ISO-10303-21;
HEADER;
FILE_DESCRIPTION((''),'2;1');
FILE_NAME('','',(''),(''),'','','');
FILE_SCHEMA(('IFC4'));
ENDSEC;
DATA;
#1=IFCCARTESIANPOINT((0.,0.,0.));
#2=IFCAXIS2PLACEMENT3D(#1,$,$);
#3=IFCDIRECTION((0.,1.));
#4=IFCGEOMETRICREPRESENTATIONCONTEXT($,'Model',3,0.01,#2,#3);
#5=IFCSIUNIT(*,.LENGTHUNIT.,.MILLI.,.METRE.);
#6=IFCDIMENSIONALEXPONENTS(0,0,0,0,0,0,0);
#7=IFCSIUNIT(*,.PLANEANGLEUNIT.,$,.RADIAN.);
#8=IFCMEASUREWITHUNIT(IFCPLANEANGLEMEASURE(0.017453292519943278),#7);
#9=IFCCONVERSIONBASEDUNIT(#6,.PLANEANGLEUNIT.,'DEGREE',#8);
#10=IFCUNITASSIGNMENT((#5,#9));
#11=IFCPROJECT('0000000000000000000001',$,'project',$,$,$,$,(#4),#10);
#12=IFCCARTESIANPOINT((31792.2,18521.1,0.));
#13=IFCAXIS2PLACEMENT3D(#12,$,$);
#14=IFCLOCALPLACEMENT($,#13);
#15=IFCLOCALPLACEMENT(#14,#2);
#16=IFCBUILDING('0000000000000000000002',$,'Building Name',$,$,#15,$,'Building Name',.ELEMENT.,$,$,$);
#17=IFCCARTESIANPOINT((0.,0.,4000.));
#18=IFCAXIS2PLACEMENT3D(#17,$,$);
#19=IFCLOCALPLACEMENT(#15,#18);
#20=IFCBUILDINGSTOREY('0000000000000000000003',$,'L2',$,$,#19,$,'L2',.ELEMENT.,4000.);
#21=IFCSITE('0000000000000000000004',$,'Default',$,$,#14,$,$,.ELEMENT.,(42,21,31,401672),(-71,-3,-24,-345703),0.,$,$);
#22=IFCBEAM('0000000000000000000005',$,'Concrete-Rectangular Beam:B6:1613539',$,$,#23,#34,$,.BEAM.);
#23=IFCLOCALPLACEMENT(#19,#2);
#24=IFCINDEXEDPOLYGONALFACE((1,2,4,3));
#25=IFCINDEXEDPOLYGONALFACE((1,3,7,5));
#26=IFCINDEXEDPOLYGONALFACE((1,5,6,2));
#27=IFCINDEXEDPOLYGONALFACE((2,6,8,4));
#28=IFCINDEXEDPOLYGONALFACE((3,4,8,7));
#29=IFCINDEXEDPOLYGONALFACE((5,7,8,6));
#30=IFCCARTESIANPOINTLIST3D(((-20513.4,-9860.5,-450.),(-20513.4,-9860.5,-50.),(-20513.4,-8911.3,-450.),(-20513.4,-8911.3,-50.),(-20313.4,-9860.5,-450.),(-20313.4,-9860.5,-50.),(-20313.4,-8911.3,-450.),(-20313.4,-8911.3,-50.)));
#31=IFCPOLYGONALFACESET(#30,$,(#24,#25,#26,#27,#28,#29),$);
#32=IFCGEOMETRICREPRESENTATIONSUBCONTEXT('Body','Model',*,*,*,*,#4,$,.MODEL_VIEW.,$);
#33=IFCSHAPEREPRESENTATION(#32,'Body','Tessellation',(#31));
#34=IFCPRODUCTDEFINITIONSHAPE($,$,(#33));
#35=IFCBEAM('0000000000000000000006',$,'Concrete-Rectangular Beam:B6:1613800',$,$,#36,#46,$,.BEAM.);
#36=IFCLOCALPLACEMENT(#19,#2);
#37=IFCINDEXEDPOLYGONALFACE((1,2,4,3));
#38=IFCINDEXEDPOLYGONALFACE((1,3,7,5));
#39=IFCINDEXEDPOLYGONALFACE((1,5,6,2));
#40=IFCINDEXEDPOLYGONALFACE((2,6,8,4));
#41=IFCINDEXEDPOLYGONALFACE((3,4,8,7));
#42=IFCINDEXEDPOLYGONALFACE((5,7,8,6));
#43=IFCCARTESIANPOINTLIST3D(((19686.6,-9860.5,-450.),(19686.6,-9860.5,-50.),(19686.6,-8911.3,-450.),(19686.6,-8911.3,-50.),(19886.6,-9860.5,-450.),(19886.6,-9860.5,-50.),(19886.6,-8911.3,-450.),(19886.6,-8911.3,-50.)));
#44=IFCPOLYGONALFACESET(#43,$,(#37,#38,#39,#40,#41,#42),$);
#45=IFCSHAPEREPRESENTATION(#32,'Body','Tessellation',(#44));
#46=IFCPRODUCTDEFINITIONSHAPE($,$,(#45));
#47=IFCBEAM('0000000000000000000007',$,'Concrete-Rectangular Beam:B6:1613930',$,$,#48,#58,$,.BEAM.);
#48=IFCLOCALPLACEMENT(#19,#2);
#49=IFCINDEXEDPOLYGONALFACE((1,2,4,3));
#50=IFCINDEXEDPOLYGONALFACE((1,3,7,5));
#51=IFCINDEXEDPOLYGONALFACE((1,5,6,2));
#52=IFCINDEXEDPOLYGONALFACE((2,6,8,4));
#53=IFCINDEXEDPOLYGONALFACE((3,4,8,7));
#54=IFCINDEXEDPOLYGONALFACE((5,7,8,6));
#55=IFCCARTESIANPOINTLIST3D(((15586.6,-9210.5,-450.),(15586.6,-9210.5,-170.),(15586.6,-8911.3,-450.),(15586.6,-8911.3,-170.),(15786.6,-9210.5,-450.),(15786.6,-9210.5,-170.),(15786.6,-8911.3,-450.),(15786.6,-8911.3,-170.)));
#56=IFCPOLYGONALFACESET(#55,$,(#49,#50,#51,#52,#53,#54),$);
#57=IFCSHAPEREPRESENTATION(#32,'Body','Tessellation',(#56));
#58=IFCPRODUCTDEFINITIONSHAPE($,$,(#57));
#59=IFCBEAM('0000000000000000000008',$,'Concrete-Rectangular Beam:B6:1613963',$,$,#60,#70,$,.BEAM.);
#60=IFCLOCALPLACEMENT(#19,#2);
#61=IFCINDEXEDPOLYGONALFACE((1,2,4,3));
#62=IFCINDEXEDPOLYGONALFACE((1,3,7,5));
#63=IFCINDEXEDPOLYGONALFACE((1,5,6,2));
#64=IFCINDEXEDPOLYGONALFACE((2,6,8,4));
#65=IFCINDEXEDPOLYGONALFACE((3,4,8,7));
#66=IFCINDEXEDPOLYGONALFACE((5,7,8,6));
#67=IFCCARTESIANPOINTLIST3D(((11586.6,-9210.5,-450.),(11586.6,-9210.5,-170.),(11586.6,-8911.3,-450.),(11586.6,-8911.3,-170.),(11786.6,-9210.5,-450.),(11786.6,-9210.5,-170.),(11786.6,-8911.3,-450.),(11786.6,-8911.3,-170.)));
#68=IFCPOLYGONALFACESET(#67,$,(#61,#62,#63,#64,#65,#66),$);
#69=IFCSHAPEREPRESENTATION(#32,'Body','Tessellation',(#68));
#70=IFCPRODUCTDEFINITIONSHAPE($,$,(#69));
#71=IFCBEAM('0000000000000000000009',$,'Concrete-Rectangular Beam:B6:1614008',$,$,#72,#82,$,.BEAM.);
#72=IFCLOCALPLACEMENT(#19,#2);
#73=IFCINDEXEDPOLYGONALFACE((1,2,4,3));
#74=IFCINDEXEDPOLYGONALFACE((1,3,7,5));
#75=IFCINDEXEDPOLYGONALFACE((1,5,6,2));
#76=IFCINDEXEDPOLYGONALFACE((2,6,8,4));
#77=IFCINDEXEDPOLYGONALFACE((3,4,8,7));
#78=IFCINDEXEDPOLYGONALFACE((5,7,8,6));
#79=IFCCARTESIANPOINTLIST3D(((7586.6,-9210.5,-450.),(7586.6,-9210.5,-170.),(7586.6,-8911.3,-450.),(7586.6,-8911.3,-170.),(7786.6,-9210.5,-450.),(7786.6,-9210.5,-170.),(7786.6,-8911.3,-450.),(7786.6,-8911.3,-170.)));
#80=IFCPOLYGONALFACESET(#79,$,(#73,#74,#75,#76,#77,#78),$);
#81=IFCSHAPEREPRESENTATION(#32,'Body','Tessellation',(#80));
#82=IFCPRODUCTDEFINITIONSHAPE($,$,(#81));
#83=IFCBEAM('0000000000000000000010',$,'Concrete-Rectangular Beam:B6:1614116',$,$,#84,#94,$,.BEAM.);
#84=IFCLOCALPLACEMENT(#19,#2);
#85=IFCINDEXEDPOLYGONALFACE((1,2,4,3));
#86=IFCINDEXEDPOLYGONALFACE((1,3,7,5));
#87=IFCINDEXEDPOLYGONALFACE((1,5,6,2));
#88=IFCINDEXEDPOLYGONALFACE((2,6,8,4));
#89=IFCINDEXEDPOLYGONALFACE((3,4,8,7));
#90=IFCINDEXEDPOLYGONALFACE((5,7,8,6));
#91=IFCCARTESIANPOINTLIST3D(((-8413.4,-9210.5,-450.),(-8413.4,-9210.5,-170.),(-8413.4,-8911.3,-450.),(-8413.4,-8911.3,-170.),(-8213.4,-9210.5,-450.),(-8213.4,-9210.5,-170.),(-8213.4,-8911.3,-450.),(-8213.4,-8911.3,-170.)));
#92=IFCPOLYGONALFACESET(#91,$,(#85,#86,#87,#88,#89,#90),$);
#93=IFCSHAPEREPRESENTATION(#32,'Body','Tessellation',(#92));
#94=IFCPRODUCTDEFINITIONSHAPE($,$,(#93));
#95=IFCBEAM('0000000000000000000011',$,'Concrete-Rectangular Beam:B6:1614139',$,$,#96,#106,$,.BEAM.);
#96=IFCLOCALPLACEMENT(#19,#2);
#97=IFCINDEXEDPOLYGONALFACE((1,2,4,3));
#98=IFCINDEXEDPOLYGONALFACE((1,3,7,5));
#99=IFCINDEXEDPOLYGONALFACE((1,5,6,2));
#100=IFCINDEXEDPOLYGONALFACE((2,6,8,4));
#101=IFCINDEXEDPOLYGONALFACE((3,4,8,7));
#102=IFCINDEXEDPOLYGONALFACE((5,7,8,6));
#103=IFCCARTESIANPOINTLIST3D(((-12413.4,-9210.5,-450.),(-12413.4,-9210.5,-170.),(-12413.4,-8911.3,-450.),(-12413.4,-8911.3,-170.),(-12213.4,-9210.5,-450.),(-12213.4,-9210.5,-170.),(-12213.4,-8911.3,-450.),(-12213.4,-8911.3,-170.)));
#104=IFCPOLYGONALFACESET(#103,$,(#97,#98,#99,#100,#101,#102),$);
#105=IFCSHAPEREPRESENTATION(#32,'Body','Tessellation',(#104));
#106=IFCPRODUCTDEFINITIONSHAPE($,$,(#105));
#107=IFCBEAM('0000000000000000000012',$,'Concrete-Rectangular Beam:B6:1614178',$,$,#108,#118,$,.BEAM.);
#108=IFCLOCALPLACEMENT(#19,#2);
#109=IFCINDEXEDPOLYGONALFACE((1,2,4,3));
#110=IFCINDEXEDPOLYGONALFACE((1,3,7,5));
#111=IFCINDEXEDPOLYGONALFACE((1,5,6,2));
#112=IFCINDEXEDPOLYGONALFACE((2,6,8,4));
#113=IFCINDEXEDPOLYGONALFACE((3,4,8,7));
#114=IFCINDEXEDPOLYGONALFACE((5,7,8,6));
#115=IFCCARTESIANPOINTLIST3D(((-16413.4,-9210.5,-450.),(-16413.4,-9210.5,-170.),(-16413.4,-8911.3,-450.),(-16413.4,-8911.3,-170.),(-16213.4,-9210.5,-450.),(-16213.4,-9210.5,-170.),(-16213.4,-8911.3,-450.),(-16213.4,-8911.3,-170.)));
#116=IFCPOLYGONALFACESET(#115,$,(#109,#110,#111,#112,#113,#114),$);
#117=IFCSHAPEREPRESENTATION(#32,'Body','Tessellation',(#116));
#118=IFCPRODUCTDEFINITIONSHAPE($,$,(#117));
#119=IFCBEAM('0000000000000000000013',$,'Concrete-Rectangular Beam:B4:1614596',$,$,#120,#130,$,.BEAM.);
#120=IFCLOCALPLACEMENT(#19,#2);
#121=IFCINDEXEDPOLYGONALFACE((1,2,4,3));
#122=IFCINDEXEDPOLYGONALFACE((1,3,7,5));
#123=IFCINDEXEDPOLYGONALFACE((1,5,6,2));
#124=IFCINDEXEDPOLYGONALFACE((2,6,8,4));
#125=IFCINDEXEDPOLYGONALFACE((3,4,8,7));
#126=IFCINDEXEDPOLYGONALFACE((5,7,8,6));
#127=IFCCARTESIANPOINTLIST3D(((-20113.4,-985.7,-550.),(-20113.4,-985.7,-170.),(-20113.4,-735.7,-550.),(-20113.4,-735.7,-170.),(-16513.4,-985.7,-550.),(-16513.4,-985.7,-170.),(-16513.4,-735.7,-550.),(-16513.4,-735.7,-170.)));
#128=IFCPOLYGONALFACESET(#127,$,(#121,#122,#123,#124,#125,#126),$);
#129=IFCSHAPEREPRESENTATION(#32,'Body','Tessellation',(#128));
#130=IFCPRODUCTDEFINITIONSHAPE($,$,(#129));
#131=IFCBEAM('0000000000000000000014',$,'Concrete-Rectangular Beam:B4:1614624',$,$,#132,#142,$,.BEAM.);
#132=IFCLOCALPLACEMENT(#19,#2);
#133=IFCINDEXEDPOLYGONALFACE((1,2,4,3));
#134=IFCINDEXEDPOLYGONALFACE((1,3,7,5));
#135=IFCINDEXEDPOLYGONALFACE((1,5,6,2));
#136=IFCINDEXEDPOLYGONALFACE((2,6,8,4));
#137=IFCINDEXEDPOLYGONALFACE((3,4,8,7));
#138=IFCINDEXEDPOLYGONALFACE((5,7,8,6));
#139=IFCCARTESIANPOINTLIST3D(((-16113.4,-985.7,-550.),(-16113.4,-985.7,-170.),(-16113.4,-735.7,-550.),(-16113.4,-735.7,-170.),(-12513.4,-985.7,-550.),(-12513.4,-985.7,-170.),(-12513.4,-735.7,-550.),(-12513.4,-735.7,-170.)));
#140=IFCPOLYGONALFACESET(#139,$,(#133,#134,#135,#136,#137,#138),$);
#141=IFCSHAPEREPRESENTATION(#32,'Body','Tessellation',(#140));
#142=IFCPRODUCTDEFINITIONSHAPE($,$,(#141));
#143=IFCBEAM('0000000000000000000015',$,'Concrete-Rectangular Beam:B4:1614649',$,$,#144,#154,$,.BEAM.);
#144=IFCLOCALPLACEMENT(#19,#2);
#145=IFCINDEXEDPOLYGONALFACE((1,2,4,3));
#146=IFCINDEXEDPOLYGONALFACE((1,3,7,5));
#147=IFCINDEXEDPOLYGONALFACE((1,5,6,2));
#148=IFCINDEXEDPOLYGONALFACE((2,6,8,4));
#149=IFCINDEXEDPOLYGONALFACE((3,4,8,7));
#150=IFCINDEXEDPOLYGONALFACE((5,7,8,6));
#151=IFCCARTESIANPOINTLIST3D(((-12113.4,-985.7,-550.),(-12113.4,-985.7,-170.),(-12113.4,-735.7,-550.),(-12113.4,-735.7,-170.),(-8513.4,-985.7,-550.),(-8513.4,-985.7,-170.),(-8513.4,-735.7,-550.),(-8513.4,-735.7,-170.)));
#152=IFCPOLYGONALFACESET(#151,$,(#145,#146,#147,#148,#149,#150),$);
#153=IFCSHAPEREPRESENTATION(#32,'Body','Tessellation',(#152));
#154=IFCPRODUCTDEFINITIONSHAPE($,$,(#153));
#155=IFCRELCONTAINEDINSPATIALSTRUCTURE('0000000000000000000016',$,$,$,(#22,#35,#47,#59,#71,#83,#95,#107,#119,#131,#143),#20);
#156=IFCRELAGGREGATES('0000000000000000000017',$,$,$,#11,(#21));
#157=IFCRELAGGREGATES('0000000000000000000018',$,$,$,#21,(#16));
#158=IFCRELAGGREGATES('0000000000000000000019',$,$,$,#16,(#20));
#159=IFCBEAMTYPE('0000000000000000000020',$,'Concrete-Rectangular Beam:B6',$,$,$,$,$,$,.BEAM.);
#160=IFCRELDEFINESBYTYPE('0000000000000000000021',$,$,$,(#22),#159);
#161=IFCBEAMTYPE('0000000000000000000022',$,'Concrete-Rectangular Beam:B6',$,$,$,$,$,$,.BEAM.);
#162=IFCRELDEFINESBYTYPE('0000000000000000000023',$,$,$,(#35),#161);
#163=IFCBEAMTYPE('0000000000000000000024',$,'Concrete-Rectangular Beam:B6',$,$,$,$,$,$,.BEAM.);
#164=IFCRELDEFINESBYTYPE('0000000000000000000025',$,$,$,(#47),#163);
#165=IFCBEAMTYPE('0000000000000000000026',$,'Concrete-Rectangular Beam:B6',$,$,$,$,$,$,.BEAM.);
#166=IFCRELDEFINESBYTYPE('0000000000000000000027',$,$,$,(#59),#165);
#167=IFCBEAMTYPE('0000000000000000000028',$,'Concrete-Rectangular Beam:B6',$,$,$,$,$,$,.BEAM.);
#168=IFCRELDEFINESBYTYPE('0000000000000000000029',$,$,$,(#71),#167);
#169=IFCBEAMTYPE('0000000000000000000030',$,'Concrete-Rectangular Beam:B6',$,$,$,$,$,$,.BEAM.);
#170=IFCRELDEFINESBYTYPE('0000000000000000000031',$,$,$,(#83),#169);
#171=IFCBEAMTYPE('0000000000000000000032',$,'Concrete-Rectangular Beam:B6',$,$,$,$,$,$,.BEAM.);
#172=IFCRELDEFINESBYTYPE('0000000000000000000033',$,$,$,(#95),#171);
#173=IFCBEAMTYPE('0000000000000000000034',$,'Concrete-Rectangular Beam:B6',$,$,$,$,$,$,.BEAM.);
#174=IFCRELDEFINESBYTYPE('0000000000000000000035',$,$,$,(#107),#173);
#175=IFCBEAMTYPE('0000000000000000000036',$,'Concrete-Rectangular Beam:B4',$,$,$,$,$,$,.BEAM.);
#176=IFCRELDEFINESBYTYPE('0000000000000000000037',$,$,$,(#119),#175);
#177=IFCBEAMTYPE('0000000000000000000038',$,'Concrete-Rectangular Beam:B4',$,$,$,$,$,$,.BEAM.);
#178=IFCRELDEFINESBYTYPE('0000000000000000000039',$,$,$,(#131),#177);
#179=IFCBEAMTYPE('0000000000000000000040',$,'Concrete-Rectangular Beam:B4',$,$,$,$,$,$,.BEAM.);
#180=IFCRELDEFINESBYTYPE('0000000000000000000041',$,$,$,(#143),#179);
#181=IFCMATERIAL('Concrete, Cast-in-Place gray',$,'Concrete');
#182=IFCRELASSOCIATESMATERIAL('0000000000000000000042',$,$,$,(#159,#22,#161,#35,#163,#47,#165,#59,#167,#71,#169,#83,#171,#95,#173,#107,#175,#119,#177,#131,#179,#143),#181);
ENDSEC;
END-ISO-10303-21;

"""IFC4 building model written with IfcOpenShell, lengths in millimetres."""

from ifc_helpers import new_model, entity, si_unit, converted_unit, direction, frame, origin, place, context, subcontext, project, spatial, indexed_curve, outline, extrude, source, transform, mapped, material, type_object, type_shapes, element, save


model = new_model("IFC4")

# Units and contexts
model_context = context("Model", 3, precision=0.01, world=origin(), true_north=direction((0.0, 1.0)))
body_context = subcontext(model_context, "Body", "Model", "MODEL_VIEW")
ifc_project = project(units=[si_unit("LENGTHUNIT", "METRE", prefix="MILLI"), converted_unit("PLANEANGLEUNIT", "DEGREE", entity("IfcPlaneAngleMeasure", 0.017453292519943278), si_unit("PLANEANGLEUNIT", "RADIAN"), dimensions=[0, 0, 0, 0, 0, 0, 0])], contexts=[model_context])

# Site, building, storey
site_placement = place(None, frame((31792.2, 18521.1, 0.0)))
site = spatial("IfcSite", under=ifc_project, at=site_placement, Name="Default", CompositionType="ELEMENT", RefLatitude=(42, 21, 31, 401672), RefLongitude=(-71, -3, -24, -345703), RefElevation=0.0)
building_placement = place(site_placement, origin())
building = spatial("IfcBuilding", under=site, at=building_placement, Name="Building Name", LongName="Building Name", CompositionType="ELEMENT")
storey_placement = place(building_placement, frame((0.0, 0.0, 4000.0)))
storey = spatial("IfcBuildingStorey", under=building, at=storey_placement, Name="L2", LongName="L2", CompositionType="ELEMENT", Elevation=4000.0)

# Beams
ifc_material = material(Name="Concrete, Cast-in-Place gray", Category="Concrete")
beam_type_1 = type_object("IfcBeamType", Name="Concrete-Rectangular Beam:B6", PredefinedType="BEAM", material=ifc_material)
shared_shape_1 = source(origin(), body_context, "Body", "SweptSolid", [
    extrude(outline(indexed_curve([(-100.0, -200.0), (100.0, -200.0), (100.0, 200.0), (-100.0, 200.0), (-100.0, -200.0)], self_intersect=False)), frame((-20413.4, -9860.5, 3750.0), z_axis=(0.0, 1.0, 0.0), x_axis=(-1.0, 0.0, 0.0)), (0.0, 0.0, 1.0), 949.2),
])
type_shapes(beam_type_1, [shared_shape_1])
beam_1_placement = place(storey_placement, frame((0.0, 0.0, -4000.0)))
element("IfcBeam", 1, at=beam_1_placement, inside=storey, type_object=beam_type_1, material=ifc_material, Name="Concrete-Rectangular Beam:B6:1613539", PredefinedType="BEAM", context=body_context, shape_type="MappedRepresentation", body=[
    mapped(shared_shape_1, transform((0.0, 0.0, 0.0), scale=1.0)),
])
beam_type_2 = type_object("IfcBeamType", Name="Concrete-Rectangular Beam:B6", PredefinedType="BEAM", material=ifc_material)
shared_shape_2 = source(origin(), body_context, "Body", "SweptSolid", [
    extrude(outline(indexed_curve([(-100.0, -200.0), (100.0, -200.0), (100.0, 200.0), (-100.0, 200.0), (-100.0, -200.0)], self_intersect=False)), frame((19786.6, -9860.5, 3750.0), z_axis=(0.0, 1.0, 0.0), x_axis=(-1.0, 0.0, 0.0)), (0.0, 0.0, 1.0), 949.2),
])
type_shapes(beam_type_2, [shared_shape_2])
beam_2_placement = place(storey_placement, frame((0.0, 0.0, -4000.0)))
element("IfcBeam", 2, at=beam_2_placement, inside=storey, type_object=beam_type_2, material=ifc_material, Name="Concrete-Rectangular Beam:B6:1613800", PredefinedType="BEAM", context=body_context, shape_type="MappedRepresentation", body=[
    mapped(shared_shape_2, transform((0.0, 0.0, 0.0), scale=1.0)),
])
beam_type_3 = type_object("IfcBeamType", Name="Concrete-Rectangular Beam:B6", PredefinedType="BEAM", material=ifc_material)
shared_shape_3 = source(origin(), body_context, "Body", "SweptSolid", [
    extrude(outline(indexed_curve([(-100.0, -140.0), (100.0, -140.0), (100.0, 140.0), (-100.0, 140.0), (-100.0, -140.0)], self_intersect=False)), frame((15686.6, -8911.3, 3690.0), z_axis=(0.0, -1.0, 0.0), x_axis=(-1.0, 0.0, 0.0)), (0.0, 0.0, 1.0), 299.2),
])
type_shapes(beam_type_3, [shared_shape_3])
beam_3_placement = place(storey_placement, frame((0.0, 0.0, -4000.0)))
element("IfcBeam", 3, at=beam_3_placement, inside=storey, type_object=beam_type_3, material=ifc_material, Name="Concrete-Rectangular Beam:B6:1613930", PredefinedType="BEAM", context=body_context, shape_type="MappedRepresentation", body=[
    mapped(shared_shape_3, transform((0.0, 0.0, 0.0), scale=1.0)),
])
beam_type_4 = type_object("IfcBeamType", Name="Concrete-Rectangular Beam:B6", PredefinedType="BEAM", material=ifc_material)
shared_shape_4 = source(origin(), body_context, "Body", "SweptSolid", [
    extrude(outline(indexed_curve([(-100.0, -140.0), (100.0, -140.0), (100.0, 140.0), (-100.0, 140.0), (-100.0, -140.0)], self_intersect=False)), frame((11686.6, -8911.3, 3690.0), z_axis=(0.0, -1.0, 0.0), x_axis=(-1.0, 0.0, 0.0)), (0.0, 0.0, 1.0), 299.2),
])
type_shapes(beam_type_4, [shared_shape_4])
beam_4_placement = place(storey_placement, frame((0.0, 0.0, -4000.0)))
element("IfcBeam", 4, at=beam_4_placement, inside=storey, type_object=beam_type_4, material=ifc_material, Name="Concrete-Rectangular Beam:B6:1613963", PredefinedType="BEAM", context=body_context, shape_type="MappedRepresentation", body=[
    mapped(shared_shape_4, transform((0.0, 0.0, 0.0), scale=1.0)),
])
beam_type_5 = type_object("IfcBeamType", Name="Concrete-Rectangular Beam:B6", PredefinedType="BEAM", material=ifc_material)
shared_shape_5 = source(origin(), body_context, "Body", "SweptSolid", [
    extrude(outline(indexed_curve([(-100.0, -140.0), (100.0, -140.0), (100.0, 140.0), (-100.0, 140.0), (-100.0, -140.0)], self_intersect=False)), frame((7686.6, -8911.3, 3690.0), z_axis=(0.0, -1.0, 0.0), x_axis=(-1.0, 0.0, 0.0)), (0.0, 0.0, 1.0), 299.2),
])
type_shapes(beam_type_5, [shared_shape_5])
beam_5_placement = place(storey_placement, frame((0.0, 0.0, -4000.0)))
element("IfcBeam", 5, at=beam_5_placement, inside=storey, type_object=beam_type_5, material=ifc_material, Name="Concrete-Rectangular Beam:B6:1614008", PredefinedType="BEAM", context=body_context, shape_type="MappedRepresentation", body=[
    mapped(shared_shape_5, transform((0.0, 0.0, 0.0), scale=1.0)),
])
beam_type_6 = type_object("IfcBeamType", Name="Concrete-Rectangular Beam:B6", PredefinedType="BEAM", material=ifc_material)
shared_shape_6 = source(origin(), body_context, "Body", "SweptSolid", [
    extrude(outline(indexed_curve([(-100.0, -140.0), (100.0, -140.0), (100.0, 140.0), (-100.0, 140.0), (-100.0, -140.0)], self_intersect=False)), frame((-8313.4, -8911.3, 3690.0), z_axis=(0.0, -1.0, 0.0), x_axis=(-1.0, 0.0, 0.0)), (0.0, 0.0, 1.0), 299.2),
])
type_shapes(beam_type_6, [shared_shape_6])
beam_6_placement = place(storey_placement, frame((0.0, 0.0, -4000.0)))
element("IfcBeam", 6, at=beam_6_placement, inside=storey, type_object=beam_type_6, material=ifc_material, Name="Concrete-Rectangular Beam:B6:1614116", PredefinedType="BEAM", context=body_context, shape_type="MappedRepresentation", body=[
    mapped(shared_shape_6, transform((0.0, 0.0, 0.0), scale=1.0)),
])
beam_type_7 = type_object("IfcBeamType", Name="Concrete-Rectangular Beam:B6", PredefinedType="BEAM", material=ifc_material)
shared_shape_7 = source(origin(), body_context, "Body", "SweptSolid", [
    extrude(outline(indexed_curve([(-100.0, -140.0), (100.0, -140.0), (100.0, 140.0), (-100.0, 140.0), (-100.0, -140.0)], self_intersect=False)), frame((-12313.4, -8911.3, 3690.0), z_axis=(0.0, -1.0, 0.0), x_axis=(-1.0, 0.0, 0.0)), (0.0, 0.0, 1.0), 299.2),
])
type_shapes(beam_type_7, [shared_shape_7])
beam_7_placement = place(storey_placement, frame((0.0, 0.0, -4000.0)))
element("IfcBeam", 7, at=beam_7_placement, inside=storey, type_object=beam_type_7, material=ifc_material, Name="Concrete-Rectangular Beam:B6:1614139", PredefinedType="BEAM", context=body_context, shape_type="MappedRepresentation", body=[
    mapped(shared_shape_7, transform((0.0, 0.0, 0.0), scale=1.0)),
])
beam_type_8 = type_object("IfcBeamType", Name="Concrete-Rectangular Beam:B6", PredefinedType="BEAM", material=ifc_material)
shared_shape_8 = source(origin(), body_context, "Body", "SweptSolid", [
    extrude(outline(indexed_curve([(-100.0, -140.0), (100.0, -140.0), (100.0, 140.0), (-100.0, 140.0), (-100.0, -140.0)], self_intersect=False)), frame((-16313.4, -8911.3, 3690.0), z_axis=(0.0, -1.0, 0.0), x_axis=(-1.0, 0.0, 0.0)), (0.0, 0.0, 1.0), 299.2),
])
type_shapes(beam_type_8, [shared_shape_8])
beam_8_placement = place(storey_placement, frame((0.0, 0.0, -4000.0)))
element("IfcBeam", 8, at=beam_8_placement, inside=storey, type_object=beam_type_8, material=ifc_material, Name="Concrete-Rectangular Beam:B6:1614178", PredefinedType="BEAM", context=body_context, shape_type="MappedRepresentation", body=[
    mapped(shared_shape_8, transform((0.0, 0.0, 0.0), scale=1.0)),
])
beam_type_9 = type_object("IfcBeamType", Name="Concrete-Rectangular Beam:B4", PredefinedType="BEAM", material=ifc_material)
shared_shape_9 = source(origin(), body_context, "Body", "SweptSolid", [
    extrude(outline(indexed_curve([(-190.0, -125.0), (190.0, -125.0), (190.0, 125.0), (-190.0, 125.0), (-190.0, -125.0)], self_intersect=False)), frame((-20113.4, -860.7, 3640.0), z_axis=(1.0, 0.0, 0.0), x_axis=(0.0, 0.0, -1.0)), (0.0, 0.0, 1.0), 3600.0),
])
type_shapes(beam_type_9, [shared_shape_9])
beam_9_placement = place(storey_placement, frame((0.0, 0.0, -4000.0)))
element("IfcBeam", 9, at=beam_9_placement, inside=storey, type_object=beam_type_9, material=ifc_material, Name="Concrete-Rectangular Beam:B4:1614596", PredefinedType="BEAM", context=body_context, shape_type="MappedRepresentation", body=[
    mapped(shared_shape_9, transform((0.0, 0.0, 0.0), scale=1.0)),
])
beam_type_10 = type_object("IfcBeamType", Name="Concrete-Rectangular Beam:B4", PredefinedType="BEAM", material=ifc_material)
shared_shape_10 = source(origin(), body_context, "Body", "SweptSolid", [
    extrude(outline(indexed_curve([(-190.0, -125.0), (190.0, -125.0), (190.0, 125.0), (-190.0, 125.0), (-190.0, -125.0)], self_intersect=False)), frame((-16113.4, -860.7, 3640.0), z_axis=(1.0, 0.0, 0.0), x_axis=(0.0, 0.0, -1.0)), (0.0, 0.0, 1.0), 3600.0),
])
type_shapes(beam_type_10, [shared_shape_10])
beam_10_placement = place(storey_placement, frame((0.0, 0.0, -4000.0)))
element("IfcBeam", 10, at=beam_10_placement, inside=storey, type_object=beam_type_10, material=ifc_material, Name="Concrete-Rectangular Beam:B4:1614624", PredefinedType="BEAM", context=body_context, shape_type="MappedRepresentation", body=[
    mapped(shared_shape_10, transform((0.0, 0.0, 0.0), scale=1.0)),
])
beam_type_11 = type_object("IfcBeamType", Name="Concrete-Rectangular Beam:B4", PredefinedType="BEAM", material=ifc_material)
shared_shape_11 = source(origin(), body_context, "Body", "SweptSolid", [
    extrude(outline(indexed_curve([(-190.0, -125.0), (190.0, -125.0), (190.0, 125.0), (-190.0, 125.0), (-190.0, -125.0)], self_intersect=False)), frame((-12113.4, -860.7, 3640.0), z_axis=(1.0, 0.0, 0.0), x_axis=(0.0, 0.0, -1.0)), (0.0, 0.0, 1.0), 3600.0),
])
type_shapes(beam_type_11, [shared_shape_11])
beam_11_placement = place(storey_placement, frame((0.0, 0.0, -4000.0)))
element("IfcBeam", 11, at=beam_11_placement, inside=storey, type_object=beam_type_11, material=ifc_material, Name="Concrete-Rectangular Beam:B4:1614649", PredefinedType="BEAM", context=body_context, shape_type="MappedRepresentation", body=[
    mapped(shared_shape_11, transform((0.0, 0.0, 0.0), scale=1.0)),
])

save(model, "model.ifc")
